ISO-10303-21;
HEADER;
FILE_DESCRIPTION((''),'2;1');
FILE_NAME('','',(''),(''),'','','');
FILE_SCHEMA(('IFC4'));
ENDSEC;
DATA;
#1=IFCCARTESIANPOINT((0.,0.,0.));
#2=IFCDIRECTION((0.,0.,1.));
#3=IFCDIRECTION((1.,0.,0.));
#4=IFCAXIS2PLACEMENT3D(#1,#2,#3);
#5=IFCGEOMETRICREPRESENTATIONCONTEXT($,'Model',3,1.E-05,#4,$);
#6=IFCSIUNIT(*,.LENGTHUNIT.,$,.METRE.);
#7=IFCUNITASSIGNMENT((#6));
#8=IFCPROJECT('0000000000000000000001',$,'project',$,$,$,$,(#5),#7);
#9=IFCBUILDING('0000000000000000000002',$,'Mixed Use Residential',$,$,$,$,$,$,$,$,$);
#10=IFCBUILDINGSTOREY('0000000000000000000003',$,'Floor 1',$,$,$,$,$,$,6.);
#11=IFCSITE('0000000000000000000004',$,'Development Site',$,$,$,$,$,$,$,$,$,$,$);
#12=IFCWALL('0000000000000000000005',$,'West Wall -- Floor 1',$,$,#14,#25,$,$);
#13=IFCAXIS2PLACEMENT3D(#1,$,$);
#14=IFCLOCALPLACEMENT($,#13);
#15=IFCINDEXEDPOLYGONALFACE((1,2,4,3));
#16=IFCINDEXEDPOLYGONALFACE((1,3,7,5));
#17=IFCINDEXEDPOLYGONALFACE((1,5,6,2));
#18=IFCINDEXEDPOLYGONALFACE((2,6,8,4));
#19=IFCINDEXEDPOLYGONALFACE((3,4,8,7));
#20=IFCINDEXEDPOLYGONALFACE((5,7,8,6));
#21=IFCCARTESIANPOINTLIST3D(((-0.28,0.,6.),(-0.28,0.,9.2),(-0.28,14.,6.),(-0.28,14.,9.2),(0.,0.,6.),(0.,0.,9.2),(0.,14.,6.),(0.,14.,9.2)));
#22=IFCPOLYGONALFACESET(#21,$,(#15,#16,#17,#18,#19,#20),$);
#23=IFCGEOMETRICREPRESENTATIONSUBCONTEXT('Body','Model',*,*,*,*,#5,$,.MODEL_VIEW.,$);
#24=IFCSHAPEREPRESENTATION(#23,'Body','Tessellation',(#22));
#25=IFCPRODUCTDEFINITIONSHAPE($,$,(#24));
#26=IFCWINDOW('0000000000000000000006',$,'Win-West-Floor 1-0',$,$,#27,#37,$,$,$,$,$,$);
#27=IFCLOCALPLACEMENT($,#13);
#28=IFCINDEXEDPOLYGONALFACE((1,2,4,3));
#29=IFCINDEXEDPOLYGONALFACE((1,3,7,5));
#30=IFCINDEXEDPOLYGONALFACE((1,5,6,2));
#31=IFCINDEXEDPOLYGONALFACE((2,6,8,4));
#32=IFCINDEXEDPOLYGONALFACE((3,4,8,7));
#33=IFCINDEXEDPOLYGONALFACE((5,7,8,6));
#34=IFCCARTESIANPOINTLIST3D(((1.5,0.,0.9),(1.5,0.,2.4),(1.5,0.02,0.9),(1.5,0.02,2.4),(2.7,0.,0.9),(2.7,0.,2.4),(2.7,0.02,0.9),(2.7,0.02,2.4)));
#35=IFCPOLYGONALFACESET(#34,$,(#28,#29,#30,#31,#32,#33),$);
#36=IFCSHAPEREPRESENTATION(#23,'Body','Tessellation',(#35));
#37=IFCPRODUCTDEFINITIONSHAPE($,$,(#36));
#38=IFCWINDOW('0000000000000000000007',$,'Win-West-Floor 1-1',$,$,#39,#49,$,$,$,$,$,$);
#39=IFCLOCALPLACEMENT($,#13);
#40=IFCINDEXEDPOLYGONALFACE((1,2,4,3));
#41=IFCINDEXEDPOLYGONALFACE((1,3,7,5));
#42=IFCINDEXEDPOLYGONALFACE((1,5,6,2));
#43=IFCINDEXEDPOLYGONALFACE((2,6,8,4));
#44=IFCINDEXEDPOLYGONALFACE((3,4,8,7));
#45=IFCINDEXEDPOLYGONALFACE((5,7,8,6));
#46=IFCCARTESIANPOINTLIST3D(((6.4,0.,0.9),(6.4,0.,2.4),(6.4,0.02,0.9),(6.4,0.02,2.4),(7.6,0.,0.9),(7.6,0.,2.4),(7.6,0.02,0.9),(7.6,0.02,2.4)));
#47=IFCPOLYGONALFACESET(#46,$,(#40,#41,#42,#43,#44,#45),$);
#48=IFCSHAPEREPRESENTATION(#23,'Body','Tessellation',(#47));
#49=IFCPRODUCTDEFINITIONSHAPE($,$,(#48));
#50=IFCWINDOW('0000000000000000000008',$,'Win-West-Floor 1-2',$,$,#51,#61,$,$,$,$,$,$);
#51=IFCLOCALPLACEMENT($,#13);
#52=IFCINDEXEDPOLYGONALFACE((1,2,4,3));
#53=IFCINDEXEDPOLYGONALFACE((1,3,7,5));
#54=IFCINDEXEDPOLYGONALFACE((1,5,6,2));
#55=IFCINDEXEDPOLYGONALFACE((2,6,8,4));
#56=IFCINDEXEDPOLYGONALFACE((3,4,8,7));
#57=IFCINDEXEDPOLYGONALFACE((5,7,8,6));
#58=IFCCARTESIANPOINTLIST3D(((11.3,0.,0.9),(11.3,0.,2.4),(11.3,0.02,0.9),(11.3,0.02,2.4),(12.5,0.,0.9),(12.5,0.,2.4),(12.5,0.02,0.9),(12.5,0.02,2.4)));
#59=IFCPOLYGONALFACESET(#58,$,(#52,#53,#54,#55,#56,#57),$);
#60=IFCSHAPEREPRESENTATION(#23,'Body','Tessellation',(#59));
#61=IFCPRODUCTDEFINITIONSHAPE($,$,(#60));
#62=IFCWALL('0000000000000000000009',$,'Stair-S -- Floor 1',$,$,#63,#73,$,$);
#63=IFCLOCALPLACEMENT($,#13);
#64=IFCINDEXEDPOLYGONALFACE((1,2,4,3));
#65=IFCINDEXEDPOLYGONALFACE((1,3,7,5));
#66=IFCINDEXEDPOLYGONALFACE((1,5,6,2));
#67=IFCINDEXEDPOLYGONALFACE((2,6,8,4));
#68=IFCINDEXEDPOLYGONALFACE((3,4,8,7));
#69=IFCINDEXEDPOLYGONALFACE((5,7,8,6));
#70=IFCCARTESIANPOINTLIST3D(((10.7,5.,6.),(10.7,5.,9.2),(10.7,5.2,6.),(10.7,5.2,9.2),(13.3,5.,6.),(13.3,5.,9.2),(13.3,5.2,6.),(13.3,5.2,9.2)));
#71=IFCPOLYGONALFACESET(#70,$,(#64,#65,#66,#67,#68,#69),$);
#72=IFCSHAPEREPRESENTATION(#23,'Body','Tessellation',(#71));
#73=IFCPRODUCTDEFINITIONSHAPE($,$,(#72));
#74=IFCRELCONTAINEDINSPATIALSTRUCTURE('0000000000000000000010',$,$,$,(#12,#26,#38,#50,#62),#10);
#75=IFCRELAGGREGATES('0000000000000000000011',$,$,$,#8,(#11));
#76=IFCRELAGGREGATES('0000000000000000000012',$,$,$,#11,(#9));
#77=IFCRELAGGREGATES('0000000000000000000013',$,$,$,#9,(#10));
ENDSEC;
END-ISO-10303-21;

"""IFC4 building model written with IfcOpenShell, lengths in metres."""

from ifc_helpers import new_model, si_unit, frame, origin_with_axes, place, context, subcontext, project, spatial, indexed_curve, outline, extrude, element, fill, save


model = new_model("IFC4")

# Units and contexts
model_context = context("Model", 3, precision=1e-05, world=origin_with_axes())
body_context = subcontext(model_context, "Body", "Model", "MODEL_VIEW")
ifc_project = project(units=[si_unit("LENGTHUNIT", "METRE")], contexts=[model_context])

# Site, building, storey
site = spatial("IfcSite", under=ifc_project, Name="Development Site")
building = spatial("IfcBuilding", under=site, Name="Mixed Use Residential")
storey = spatial("IfcBuildingStorey", under=building, Name="Floor 1", Elevation=6.0)

# Wall, openings, windows
wall_1_placement = place(None, frame((0.0, 0.0, 6.0), z_axis=(0.0, 0.0, 1.0), x_axis=(0.0, 1.0, 0.0)))
wall_1 = element("IfcWall", 1, at=wall_1_placement, inside=storey, Name="West Wall -- Floor 1", context=body_context, shape_type="SweptSolid", body=[
    extrude(outline(indexed_curve([(0.0, 0.0), (0.0, 0.28), (14.0, 0.28), (14.0, 0.0), (0.0, 0.0)], self_intersect=False)), origin_with_axes(), (0.0, 0.0, 1.0), 3.2),
])
opening_1_placement = place(wall_1_placement, frame((0.0, -1.5, -5.1), z_axis=(0.0, 0.0, 1.0), x_axis=(0.0, -1.0, 0.0)))
opening_1 = element("IfcOpeningElement", 2, at=opening_1_placement, cuts=wall_1, context=body_context, shape_type="SweptSolid", body=[
    extrude(outline(indexed_curve([(0.0, 0.0), (0.0, 0.28), (1.2, 0.28), (1.2, 0.0), (0.0, 0.0)], self_intersect=False)), origin_with_axes(), (0.0, 0.0, 1.0), 1.5),
])
opening_2_placement = place(wall_1_placement, frame((0.0, -6.4, -5.1), z_axis=(0.0, 0.0, 1.0), x_axis=(0.0, -1.0, 0.0)))
opening_2 = element("IfcOpeningElement", 3, at=opening_2_placement, cuts=wall_1, context=body_context, shape_type="SweptSolid", body=[
    extrude(outline(indexed_curve([(0.0, 0.0), (0.0, 0.28), (1.2, 0.28), (1.2, 0.0), (0.0, 0.0)], self_intersect=False)), origin_with_axes(), (0.0, 0.0, 1.0), 1.5),
])
opening_3_placement = place(wall_1_placement, frame((0.0, -11.3, -5.1), z_axis=(0.0, 0.0, 1.0), x_axis=(0.0, -1.0, 0.0)))
opening_3 = element("IfcOpeningElement", 4, at=opening_3_placement, cuts=wall_1, context=body_context, shape_type="SweptSolid", body=[
    extrude(outline(indexed_curve([(0.0, 0.0), (0.0, 0.28), (1.2, 0.28), (1.2, 0.0), (0.0, 0.0)], self_intersect=False)), origin_with_axes(), (0.0, 0.0, 1.0), 1.5),
])
window_1_placement = place(None, frame((1.5, 0.0, 0.9), z_axis=(0.0, 0.0, 1.0), x_axis=(1.0, 0.0, 0.0)))
window_1 = element("IfcWindow", 5, at=window_1_placement, inside=storey, Name="Win-West-Floor 1-0", context=body_context, shape_type="SweptSolid", body=[
    extrude(outline(indexed_curve([(0.0, 0.0), (0.0, 0.02), (1.2, 0.02), (1.2, 0.0), (0.0, 0.0)], self_intersect=False)), origin_with_axes(), (0.0, 0.0, 1.0), 1.5),
])
fill(opening_1, window_1)
window_2_placement = place(None, frame((6.4, 0.0, 0.9), z_axis=(0.0, 0.0, 1.0), x_axis=(1.0, 0.0, 0.0)))
window_2 = element("IfcWindow", 6, at=window_2_placement, inside=storey, Name="Win-West-Floor 1-1", context=body_context, shape_type="SweptSolid", body=[
    extrude(outline(indexed_curve([(0.0, 0.0), (0.0, 0.02), (1.2, 0.02), (1.2, 0.0), (0.0, 0.0)], self_intersect=False)), origin_with_axes(), (0.0, 0.0, 1.0), 1.5),
])
fill(opening_2, window_2)
window_3_placement = place(None, frame((11.3, 0.0, 0.9), z_axis=(0.0, 0.0, 1.0), x_axis=(1.0, 0.0, 0.0)))
window_3 = element("IfcWindow", 7, at=window_3_placement, inside=storey, Name="Win-West-Floor 1-2", context=body_context, shape_type="SweptSolid", body=[
    extrude(outline(indexed_curve([(0.0, 0.0), (0.0, 0.02), (1.2, 0.02), (1.2, 0.0), (0.0, 0.0)], self_intersect=False)), origin_with_axes(), (0.0, 0.0, 1.0), 1.5),
])
fill(opening_3, window_3)

# Wall
wall_2_placement = place(None, frame((10.7, 5.0, 6.0), z_axis=(0.0, 0.0, 1.0), x_axis=(1.0, 0.0, 0.0)))
element("IfcWall", 8, at=wall_2_placement, inside=storey, Name="Stair-S -- Floor 1", context=body_context, shape_type="SweptSolid", body=[
    extrude(outline(indexed_curve([(0.0, 0.0), (0.0, 0.2), (2.6, 0.2), (2.6, 0.0), (0.0, 0.0)], self_intersect=False)), origin_with_axes(), (0.0, 0.0, 1.0), 3.2),
])

save(model, "model.ifc")
